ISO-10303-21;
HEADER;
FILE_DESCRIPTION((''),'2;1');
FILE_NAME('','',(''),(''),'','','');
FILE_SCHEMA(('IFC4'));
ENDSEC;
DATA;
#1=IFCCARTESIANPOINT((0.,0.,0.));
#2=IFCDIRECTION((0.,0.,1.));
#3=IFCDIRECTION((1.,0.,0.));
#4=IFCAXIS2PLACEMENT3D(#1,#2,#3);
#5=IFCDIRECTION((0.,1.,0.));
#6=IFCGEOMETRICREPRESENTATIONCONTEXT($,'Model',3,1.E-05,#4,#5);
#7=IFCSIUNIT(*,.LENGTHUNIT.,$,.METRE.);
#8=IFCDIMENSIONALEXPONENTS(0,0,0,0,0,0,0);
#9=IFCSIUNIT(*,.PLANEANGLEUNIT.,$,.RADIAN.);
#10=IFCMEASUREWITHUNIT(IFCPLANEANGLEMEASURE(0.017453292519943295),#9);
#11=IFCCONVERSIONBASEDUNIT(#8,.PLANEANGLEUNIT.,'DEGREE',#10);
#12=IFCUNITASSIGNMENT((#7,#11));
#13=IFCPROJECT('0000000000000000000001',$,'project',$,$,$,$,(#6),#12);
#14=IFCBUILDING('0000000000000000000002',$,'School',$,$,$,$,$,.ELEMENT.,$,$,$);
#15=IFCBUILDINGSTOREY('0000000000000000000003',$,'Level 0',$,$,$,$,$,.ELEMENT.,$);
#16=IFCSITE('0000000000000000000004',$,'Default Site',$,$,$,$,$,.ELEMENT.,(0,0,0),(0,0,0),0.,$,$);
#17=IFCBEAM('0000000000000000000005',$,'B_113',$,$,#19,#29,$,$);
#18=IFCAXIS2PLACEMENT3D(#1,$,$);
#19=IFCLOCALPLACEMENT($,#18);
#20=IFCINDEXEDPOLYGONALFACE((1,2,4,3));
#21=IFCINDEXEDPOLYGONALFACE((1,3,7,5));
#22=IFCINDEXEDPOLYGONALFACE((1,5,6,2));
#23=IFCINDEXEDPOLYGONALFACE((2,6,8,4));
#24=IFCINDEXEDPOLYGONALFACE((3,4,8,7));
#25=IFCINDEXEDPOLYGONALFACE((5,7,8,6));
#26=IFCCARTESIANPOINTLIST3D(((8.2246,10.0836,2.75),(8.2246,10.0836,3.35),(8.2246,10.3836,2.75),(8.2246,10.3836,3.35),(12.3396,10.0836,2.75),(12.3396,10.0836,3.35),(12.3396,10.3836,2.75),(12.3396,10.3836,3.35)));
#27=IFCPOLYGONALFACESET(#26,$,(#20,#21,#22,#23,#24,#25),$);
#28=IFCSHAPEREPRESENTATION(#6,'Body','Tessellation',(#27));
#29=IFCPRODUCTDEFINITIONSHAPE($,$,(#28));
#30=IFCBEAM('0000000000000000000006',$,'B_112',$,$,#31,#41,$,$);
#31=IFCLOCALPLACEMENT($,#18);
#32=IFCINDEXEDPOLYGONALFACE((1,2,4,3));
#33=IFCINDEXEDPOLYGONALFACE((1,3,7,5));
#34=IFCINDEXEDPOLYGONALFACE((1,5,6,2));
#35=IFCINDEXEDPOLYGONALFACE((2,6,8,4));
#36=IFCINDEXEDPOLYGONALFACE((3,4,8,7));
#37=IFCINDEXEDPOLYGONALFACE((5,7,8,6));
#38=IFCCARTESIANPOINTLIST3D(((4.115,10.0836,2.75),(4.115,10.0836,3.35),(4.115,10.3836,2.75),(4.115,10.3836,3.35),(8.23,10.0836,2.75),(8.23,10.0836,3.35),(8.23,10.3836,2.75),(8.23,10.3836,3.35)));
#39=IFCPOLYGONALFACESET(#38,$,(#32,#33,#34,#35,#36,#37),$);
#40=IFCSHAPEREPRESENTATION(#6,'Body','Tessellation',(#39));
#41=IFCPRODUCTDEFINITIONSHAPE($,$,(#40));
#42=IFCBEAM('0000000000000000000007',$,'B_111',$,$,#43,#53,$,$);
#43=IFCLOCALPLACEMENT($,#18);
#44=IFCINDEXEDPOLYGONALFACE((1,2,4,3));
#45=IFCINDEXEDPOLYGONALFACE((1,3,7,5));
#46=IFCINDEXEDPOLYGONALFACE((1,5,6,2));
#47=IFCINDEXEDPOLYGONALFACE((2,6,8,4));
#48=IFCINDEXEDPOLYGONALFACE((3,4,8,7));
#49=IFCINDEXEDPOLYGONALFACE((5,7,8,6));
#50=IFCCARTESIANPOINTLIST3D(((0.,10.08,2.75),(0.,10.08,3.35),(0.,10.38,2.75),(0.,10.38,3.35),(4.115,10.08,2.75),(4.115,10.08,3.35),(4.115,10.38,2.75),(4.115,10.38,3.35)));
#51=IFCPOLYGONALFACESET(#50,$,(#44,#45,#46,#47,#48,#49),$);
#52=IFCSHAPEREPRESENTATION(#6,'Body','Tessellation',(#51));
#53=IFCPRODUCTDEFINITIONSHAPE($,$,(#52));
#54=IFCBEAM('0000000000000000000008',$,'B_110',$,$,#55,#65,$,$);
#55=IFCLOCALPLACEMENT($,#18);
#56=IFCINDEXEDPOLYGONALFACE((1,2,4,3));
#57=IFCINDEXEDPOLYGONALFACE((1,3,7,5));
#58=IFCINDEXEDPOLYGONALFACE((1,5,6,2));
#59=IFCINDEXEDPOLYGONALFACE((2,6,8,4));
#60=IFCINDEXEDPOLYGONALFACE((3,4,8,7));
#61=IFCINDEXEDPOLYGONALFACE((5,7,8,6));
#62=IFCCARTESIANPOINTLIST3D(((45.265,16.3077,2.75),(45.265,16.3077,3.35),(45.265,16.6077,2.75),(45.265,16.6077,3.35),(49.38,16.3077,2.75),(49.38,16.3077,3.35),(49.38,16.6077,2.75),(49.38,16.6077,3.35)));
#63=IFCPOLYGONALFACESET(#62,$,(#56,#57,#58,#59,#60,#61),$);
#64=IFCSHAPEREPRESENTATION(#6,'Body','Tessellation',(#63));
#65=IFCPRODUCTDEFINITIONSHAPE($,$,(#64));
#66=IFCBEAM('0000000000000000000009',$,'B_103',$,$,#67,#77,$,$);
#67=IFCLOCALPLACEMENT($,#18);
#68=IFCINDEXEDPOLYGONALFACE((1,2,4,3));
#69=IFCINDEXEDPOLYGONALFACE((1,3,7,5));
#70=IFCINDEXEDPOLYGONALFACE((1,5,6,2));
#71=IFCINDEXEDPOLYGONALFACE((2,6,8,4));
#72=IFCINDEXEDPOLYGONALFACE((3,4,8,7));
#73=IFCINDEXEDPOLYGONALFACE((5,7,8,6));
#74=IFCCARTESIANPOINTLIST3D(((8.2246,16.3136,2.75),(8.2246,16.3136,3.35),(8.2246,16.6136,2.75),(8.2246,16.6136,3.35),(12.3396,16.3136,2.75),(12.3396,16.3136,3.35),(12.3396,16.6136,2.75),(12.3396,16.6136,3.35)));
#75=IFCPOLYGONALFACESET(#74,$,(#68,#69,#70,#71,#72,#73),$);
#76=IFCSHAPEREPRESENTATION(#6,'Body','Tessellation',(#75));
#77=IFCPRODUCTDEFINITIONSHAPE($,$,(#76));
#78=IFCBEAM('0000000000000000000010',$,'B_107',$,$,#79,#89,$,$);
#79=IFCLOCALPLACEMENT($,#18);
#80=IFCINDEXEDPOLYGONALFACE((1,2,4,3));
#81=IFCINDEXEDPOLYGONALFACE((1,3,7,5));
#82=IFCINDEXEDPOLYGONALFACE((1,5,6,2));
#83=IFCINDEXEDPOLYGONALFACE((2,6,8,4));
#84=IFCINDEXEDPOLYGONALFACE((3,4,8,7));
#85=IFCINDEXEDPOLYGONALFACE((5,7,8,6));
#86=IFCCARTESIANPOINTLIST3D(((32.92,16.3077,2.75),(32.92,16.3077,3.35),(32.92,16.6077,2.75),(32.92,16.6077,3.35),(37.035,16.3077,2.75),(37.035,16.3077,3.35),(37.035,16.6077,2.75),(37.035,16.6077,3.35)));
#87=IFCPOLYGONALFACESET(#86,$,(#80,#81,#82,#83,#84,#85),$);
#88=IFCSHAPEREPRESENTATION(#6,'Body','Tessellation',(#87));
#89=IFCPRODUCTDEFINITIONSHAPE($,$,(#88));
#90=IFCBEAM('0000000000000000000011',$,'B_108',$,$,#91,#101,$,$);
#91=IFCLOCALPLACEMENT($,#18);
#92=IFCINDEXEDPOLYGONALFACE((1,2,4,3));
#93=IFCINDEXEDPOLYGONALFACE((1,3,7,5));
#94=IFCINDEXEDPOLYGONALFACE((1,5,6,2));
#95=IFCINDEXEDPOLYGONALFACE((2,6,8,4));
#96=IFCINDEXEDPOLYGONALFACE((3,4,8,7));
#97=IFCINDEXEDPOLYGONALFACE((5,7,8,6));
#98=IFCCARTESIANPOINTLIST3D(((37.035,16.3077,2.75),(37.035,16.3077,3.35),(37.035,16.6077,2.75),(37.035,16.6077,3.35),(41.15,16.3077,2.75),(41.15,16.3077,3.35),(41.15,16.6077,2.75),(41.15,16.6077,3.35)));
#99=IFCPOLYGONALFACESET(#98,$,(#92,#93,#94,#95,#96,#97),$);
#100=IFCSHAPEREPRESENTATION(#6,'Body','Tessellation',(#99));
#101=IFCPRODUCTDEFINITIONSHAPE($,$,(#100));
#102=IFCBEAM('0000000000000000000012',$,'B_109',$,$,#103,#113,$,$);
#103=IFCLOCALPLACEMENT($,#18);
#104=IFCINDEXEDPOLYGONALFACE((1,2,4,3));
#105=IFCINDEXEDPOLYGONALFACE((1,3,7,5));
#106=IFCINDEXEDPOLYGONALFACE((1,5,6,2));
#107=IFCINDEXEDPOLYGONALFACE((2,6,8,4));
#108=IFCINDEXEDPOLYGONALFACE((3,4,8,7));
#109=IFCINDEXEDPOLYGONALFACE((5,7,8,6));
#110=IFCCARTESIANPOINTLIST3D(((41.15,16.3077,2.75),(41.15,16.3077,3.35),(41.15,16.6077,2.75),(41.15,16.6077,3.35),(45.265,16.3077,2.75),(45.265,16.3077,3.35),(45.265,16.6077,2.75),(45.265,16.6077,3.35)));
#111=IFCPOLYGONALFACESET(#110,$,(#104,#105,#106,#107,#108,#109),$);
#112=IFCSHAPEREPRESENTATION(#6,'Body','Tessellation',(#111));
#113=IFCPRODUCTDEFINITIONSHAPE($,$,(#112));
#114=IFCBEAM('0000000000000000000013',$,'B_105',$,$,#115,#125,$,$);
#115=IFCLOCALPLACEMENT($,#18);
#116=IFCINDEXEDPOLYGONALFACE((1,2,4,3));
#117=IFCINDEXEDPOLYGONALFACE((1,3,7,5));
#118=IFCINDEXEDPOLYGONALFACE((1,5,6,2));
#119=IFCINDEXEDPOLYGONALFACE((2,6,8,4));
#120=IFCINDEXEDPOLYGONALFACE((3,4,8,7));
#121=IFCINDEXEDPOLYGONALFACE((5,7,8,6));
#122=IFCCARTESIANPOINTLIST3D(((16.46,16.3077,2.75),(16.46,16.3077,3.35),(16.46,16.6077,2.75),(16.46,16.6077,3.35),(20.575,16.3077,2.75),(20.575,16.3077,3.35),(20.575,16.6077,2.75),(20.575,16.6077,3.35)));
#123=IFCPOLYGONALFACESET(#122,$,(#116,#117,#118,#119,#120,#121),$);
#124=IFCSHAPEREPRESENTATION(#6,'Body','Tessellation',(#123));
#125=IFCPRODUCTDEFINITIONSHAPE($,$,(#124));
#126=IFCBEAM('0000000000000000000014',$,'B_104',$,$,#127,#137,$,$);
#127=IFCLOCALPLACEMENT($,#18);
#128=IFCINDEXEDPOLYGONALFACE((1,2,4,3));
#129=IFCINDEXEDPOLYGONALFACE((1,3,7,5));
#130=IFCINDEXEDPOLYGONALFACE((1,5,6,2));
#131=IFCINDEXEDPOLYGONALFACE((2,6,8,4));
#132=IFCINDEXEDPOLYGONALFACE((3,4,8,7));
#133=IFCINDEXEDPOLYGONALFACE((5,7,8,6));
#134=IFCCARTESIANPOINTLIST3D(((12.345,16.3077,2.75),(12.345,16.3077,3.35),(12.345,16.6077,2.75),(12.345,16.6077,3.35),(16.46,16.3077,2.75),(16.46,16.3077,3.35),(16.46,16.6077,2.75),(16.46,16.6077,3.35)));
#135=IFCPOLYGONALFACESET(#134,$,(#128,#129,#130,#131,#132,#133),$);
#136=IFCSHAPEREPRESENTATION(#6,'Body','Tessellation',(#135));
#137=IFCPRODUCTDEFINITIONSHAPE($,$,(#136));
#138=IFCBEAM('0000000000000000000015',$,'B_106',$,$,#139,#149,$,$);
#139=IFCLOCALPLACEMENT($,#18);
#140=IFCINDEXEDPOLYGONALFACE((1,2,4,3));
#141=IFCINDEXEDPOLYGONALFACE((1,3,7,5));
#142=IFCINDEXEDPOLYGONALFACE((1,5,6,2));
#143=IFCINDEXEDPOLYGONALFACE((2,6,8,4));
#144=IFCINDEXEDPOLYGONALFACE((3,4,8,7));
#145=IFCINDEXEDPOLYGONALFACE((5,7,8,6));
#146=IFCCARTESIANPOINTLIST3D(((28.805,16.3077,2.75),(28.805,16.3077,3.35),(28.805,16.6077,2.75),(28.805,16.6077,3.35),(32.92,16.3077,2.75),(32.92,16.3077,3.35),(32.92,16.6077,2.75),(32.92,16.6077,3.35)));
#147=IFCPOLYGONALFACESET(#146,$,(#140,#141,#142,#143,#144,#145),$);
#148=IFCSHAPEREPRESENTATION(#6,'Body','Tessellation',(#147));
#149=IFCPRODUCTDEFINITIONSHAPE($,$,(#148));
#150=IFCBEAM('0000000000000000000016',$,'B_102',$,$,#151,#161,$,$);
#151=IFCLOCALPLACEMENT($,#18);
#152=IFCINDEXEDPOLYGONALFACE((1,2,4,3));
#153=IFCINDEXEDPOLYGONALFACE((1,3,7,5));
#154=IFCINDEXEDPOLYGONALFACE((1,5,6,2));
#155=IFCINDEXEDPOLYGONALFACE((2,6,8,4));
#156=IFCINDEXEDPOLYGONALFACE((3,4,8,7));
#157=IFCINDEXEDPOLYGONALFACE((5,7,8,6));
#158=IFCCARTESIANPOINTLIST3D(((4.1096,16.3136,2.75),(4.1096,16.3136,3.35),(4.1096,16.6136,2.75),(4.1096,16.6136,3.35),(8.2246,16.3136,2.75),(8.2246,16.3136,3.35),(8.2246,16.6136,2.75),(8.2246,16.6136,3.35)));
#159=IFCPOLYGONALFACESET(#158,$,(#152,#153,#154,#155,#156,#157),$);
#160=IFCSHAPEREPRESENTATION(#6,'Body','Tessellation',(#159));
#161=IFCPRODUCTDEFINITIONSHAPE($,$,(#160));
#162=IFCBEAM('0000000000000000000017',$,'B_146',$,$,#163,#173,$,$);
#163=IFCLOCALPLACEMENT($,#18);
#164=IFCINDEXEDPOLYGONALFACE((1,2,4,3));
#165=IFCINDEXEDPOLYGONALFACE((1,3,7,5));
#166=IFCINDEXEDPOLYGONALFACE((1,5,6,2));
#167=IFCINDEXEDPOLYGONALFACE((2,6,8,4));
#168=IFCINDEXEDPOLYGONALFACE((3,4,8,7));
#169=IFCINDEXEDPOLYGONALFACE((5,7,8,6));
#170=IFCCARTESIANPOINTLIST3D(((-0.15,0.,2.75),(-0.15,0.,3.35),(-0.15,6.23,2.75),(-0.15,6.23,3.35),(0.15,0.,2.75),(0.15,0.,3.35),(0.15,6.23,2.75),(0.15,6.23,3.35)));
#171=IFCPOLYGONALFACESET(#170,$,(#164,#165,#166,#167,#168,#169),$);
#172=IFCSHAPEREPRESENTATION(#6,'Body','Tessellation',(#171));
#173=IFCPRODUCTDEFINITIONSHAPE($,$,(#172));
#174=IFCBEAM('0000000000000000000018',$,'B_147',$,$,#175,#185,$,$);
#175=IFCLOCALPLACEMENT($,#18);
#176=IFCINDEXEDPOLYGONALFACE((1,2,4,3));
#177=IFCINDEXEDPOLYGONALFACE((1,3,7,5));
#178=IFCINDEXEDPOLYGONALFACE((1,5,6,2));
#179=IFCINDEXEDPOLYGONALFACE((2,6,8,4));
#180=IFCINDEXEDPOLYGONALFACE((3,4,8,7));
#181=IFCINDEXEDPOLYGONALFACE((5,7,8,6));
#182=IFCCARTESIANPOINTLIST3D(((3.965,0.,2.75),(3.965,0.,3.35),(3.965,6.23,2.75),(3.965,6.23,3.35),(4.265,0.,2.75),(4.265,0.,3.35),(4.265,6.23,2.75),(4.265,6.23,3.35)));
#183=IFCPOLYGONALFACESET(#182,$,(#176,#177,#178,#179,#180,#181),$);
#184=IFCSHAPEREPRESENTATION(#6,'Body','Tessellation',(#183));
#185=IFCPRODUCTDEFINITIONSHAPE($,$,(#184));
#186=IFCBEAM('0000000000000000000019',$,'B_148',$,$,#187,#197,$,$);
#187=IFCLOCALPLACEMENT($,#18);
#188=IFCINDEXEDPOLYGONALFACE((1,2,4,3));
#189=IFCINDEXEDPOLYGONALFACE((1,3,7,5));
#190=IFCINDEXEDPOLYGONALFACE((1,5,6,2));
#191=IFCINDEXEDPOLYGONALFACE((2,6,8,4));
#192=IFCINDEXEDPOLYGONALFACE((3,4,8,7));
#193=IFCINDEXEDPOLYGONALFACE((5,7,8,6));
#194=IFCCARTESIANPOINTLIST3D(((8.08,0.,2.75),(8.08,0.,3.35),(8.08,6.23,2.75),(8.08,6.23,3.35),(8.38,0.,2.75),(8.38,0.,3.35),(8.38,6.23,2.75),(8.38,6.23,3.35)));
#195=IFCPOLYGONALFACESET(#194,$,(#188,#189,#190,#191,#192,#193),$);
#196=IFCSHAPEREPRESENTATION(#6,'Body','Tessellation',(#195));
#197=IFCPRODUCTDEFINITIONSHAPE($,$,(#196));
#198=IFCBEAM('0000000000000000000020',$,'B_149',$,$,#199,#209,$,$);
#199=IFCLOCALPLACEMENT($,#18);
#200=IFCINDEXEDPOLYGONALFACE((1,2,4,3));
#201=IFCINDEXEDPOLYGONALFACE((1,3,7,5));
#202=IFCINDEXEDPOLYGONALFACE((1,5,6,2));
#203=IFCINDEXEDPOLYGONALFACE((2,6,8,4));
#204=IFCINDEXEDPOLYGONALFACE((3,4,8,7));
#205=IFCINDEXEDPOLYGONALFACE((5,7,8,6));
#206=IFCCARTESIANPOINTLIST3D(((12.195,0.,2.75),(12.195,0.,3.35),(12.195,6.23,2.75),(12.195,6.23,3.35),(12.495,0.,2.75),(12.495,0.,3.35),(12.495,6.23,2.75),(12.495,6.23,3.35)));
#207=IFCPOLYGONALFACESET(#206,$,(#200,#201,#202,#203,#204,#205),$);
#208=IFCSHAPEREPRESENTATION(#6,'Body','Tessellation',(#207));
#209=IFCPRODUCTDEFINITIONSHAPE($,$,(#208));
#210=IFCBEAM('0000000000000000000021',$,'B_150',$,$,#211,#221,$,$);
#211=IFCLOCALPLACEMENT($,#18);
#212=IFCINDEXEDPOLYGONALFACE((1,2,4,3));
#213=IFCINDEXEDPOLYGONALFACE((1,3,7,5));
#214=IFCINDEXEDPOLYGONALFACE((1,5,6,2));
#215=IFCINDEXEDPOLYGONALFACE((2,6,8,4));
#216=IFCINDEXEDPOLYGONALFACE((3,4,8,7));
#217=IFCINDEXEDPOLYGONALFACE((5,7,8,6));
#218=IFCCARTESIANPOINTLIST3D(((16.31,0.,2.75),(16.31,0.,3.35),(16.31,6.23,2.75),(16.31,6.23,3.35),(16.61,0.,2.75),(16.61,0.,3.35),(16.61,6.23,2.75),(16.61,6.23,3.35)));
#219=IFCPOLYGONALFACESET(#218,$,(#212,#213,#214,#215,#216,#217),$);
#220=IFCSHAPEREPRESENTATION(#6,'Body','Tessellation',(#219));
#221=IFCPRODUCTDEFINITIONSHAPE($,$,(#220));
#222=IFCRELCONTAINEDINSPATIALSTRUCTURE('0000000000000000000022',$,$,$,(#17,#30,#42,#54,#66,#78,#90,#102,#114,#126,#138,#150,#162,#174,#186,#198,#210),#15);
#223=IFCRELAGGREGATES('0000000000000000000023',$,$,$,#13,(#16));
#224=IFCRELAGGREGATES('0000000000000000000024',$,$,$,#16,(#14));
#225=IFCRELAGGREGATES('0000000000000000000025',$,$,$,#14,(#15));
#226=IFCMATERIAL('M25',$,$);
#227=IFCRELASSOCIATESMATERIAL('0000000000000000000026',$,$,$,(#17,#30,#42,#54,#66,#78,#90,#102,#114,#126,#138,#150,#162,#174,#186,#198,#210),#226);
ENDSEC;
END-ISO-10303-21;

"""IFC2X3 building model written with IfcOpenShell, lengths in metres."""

from ifc_helpers import new_model, entity, si_unit, converted_unit, direction, frame, frame_2d, origin_with_axes, place, context, project, spatial, rectangle, extrude, material, element, save


model = new_model("IFC2X3")

# Units and contexts
model_context = context("Model", 3, precision=1e-05, world=origin_with_axes(), true_north=direction((0.0, 1.0, 0.0)))
ifc_project = project(units=[si_unit("LENGTHUNIT", "METRE"), converted_unit("PLANEANGLEUNIT", "DEGREE", entity("IfcPlaneAngleMeasure", 0.017453292519943295), si_unit("PLANEANGLEUNIT", "RADIAN"), dimensions=[0, 0, 0, 0, 0, 0, 0])], contexts=[model_context])

# Site, building, storey
site = spatial("IfcSite", under=ifc_project, Name="Default Site", CompositionType="ELEMENT", RefLatitude=(0, 0, 0), RefLongitude=(0, 0, 0), RefElevation=0.0)
building = spatial("IfcBuilding", under=site, Name="School", CompositionType="ELEMENT")
storey = spatial("IfcBuildingStorey", under=building, Name="Level 0", CompositionType="ELEMENT")

# Beams
ifc_material = material(Name="M25")
placement = place(None, origin_with_axes())
element("IfcBeam", 1, at=placement, inside=storey, material=ifc_material, Name="B_113", context=model_context, shape_type="SweptSolid", body=[
    extrude(rectangle(XDim=0.3, YDim=0.6, at=frame_2d((0.0, 0.0), x_axis=(0.0, 1.0, 0.0))), frame((8.2246, 10.2336, 3.05), z_axis=(1.0, 0.0, 0.0), x_axis=(0.0, 0.0, -1.0)), (0.0, 0.0, 1.0), 4.115),
])
element("IfcBeam", 2, at=placement, inside=storey, material=ifc_material, Name="B_112", context=model_context, shape_type="SweptSolid", body=[
    extrude(rectangle(XDim=0.3, YDim=0.6, at=frame_2d((0.0, 0.0), x_axis=(0.0, 1.0, 0.0))), frame((4.115, 10.2336, 3.05), z_axis=(1.0, 0.0, 0.0), x_axis=(0.0, 0.0, -1.0)), (0.0, 0.0, 1.0), 4.115),
])
element("IfcBeam", 3, at=placement, inside=storey, material=ifc_material, Name="B_111", context=model_context, shape_type="SweptSolid", body=[
    extrude(rectangle(XDim=0.3, YDim=0.6, at=frame_2d((0.0, 0.0), x_axis=(0.0, 1.0, 0.0))), frame((0.0, 10.23, 3.05), z_axis=(1.0, 0.0, 0.0), x_axis=(0.0, 0.0, -1.0)), (0.0, 0.0, 1.0), 4.115),
])
element("IfcBeam", 4, at=placement, inside=storey, material=ifc_material, Name="B_110", context=model_context, shape_type="SweptSolid", body=[
    extrude(rectangle(XDim=0.3, YDim=0.6, at=frame_2d((0.0, 0.0), x_axis=(0.0, 1.0, 0.0))), frame((45.265, 16.4577, 3.05), z_axis=(1.0, 0.0, 0.0), x_axis=(0.0, 0.0, -1.0)), (0.0, 0.0, 1.0), 4.115),
])
element("IfcBeam", 5, at=placement, inside=storey, material=ifc_material, Name="B_103", context=model_context, shape_type="SweptSolid", body=[
    extrude(rectangle(XDim=0.3, YDim=0.6, at=frame_2d((0.0, 0.0), x_axis=(0.0, 1.0, 0.0))), frame((8.2246, 16.4636, 3.05), z_axis=(1.0, 0.0, 0.0), x_axis=(0.0, 0.0, -1.0)), (0.0, 0.0, 1.0), 4.115),
])
element("IfcBeam", 6, at=placement, inside=storey, material=ifc_material, Name="B_107", context=model_context, shape_type="SweptSolid", body=[
    extrude(rectangle(XDim=0.3, YDim=0.6, at=frame_2d((0.0, 0.0), x_axis=(0.0, 1.0, 0.0))), frame((32.92, 16.4577, 3.05), z_axis=(1.0, 0.0, 0.0), x_axis=(0.0, 0.0, -1.0)), (0.0, 0.0, 1.0), 4.115),
])
element("IfcBeam", 7, at=placement, inside=storey, material=ifc_material, Name="B_108", context=model_context, shape_type="SweptSolid", body=[
    extrude(rectangle(XDim=0.3, YDim=0.6, at=frame_2d((0.0, 0.0), x_axis=(0.0, 1.0, 0.0))), frame((37.035, 16.4577, 3.05), z_axis=(1.0, 0.0, 0.0), x_axis=(0.0, 0.0, -1.0)), (0.0, 0.0, 1.0), 4.115),
])
element("IfcBeam", 8, at=placement, inside=storey, material=ifc_material, Name="B_109", context=model_context, shape_type="SweptSolid", body=[
    extrude(rectangle(XDim=0.3, YDim=0.6, at=frame_2d((0.0, 0.0), x_axis=(0.0, 1.0, 0.0))), frame((41.15, 16.4577, 3.05), z_axis=(1.0, 0.0, 0.0), x_axis=(0.0, 0.0, -1.0)), (0.0, 0.0, 1.0), 4.115),
])
element("IfcBeam", 9, at=placement, inside=storey, material=ifc_material, Name="B_105", context=model_context, shape_type="SweptSolid", body=[
    extrude(rectangle(XDim=0.3, YDim=0.6, at=frame_2d((0.0, 0.0), x_axis=(0.0, 1.0, 0.0))), frame((16.46, 16.4577, 3.05), z_axis=(1.0, 0.0, 0.0), x_axis=(0.0, 0.0, -1.0)), (0.0, 0.0, 1.0), 4.115),
])
element("IfcBeam", 10, at=placement, inside=storey, material=ifc_material, Name="B_104", context=model_context, shape_type="SweptSolid", body=[
    extrude(rectangle(XDim=0.3, YDim=0.6, at=frame_2d((0.0, 0.0), x_axis=(0.0, 1.0, 0.0))), frame((12.345, 16.4577, 3.05), z_axis=(1.0, 0.0, 0.0), x_axis=(0.0, 0.0, -1.0)), (0.0, 0.0, 1.0), 4.115),
])
element("IfcBeam", 11, at=placement, inside=storey, material=ifc_material, Name="B_106", context=model_context, shape_type="SweptSolid", body=[
    extrude(rectangle(XDim=0.3, YDim=0.6, at=frame_2d((0.0, 0.0), x_axis=(0.0, 1.0, 0.0))), frame((28.805, 16.4577, 3.05), z_axis=(1.0, 0.0, 0.0), x_axis=(0.0, 0.0, -1.0)), (0.0, 0.0, 1.0), 4.115),
])
element("IfcBeam", 12, at=placement, inside=storey, material=ifc_material, Name="B_102", context=model_context, shape_type="SweptSolid", body=[
    extrude(rectangle(XDim=0.3, YDim=0.6, at=frame_2d((0.0, 0.0), x_axis=(0.0, 1.0, 0.0))), frame((4.1096, 16.4636, 3.05), z_axis=(1.0, 0.0, 0.0), x_axis=(0.0, 0.0, -1.0)), (0.0, 0.0, 1.0), 4.115),
])
element("IfcBeam", 13, at=placement, inside=storey, material=ifc_material, Name="B_146", context=model_context, shape_type="SweptSolid", body=[
    extrude(rectangle(XDim=0.3, YDim=0.6, at=frame_2d((0.0, 0.0), x_axis=(0.0, 1.0, 0.0))), frame((0.0, 0.0, 3.05), z_axis=(0.0, 1.0, 0.0), x_axis=(0.0, 0.0, -1.0)), (0.0, 0.0, 1.0), 6.23),
])
element("IfcBeam", 14, at=placement, inside=storey, material=ifc_material, Name="B_147", context=model_context, shape_type="SweptSolid", body=[
    extrude(rectangle(XDim=0.3, YDim=0.6, at=frame_2d((0.0, 0.0), x_axis=(0.0, 1.0, 0.0))), frame((4.115, 0.0, 3.05), z_axis=(0.0, 1.0, 0.0), x_axis=(0.0, 0.0, -1.0)), (0.0, 0.0, 1.0), 6.23),
])
element("IfcBeam", 15, at=placement, inside=storey, material=ifc_material, Name="B_148", context=model_context, shape_type="SweptSolid", body=[
    extrude(rectangle(XDim=0.3, YDim=0.6, at=frame_2d((0.0, 0.0), x_axis=(0.0, 1.0, 0.0))), frame((8.23, 0.0, 3.05), z_axis=(0.0, 1.0, 0.0), x_axis=(0.0, 0.0, -1.0)), (0.0, 0.0, 1.0), 6.23),
])
element("IfcBeam", 16, at=placement, inside=storey, material=ifc_material, Name="B_149", context=model_context, shape_type="SweptSolid", body=[
    extrude(rectangle(XDim=0.3, YDim=0.6, at=frame_2d((0.0, 0.0), x_axis=(0.0, 1.0, 0.0))), frame((12.345, 0.0, 3.05), z_axis=(0.0, 1.0, 0.0), x_axis=(0.0, 0.0, -1.0)), (0.0, 0.0, 1.0), 6.23),
])
element("IfcBeam", 17, at=placement, inside=storey, material=ifc_material, Name="B_150", context=model_context, shape_type="SweptSolid", body=[
    extrude(rectangle(XDim=0.3, YDim=0.6, at=frame_2d((0.0, 0.0), x_axis=(0.0, 1.0, 0.0))), frame((16.46, 0.0, 3.05), z_axis=(0.0, 1.0, 0.0), x_axis=(0.0, 0.0, -1.0)), (0.0, 0.0, 1.0), 6.23),
])

save(model, "model.ifc")
